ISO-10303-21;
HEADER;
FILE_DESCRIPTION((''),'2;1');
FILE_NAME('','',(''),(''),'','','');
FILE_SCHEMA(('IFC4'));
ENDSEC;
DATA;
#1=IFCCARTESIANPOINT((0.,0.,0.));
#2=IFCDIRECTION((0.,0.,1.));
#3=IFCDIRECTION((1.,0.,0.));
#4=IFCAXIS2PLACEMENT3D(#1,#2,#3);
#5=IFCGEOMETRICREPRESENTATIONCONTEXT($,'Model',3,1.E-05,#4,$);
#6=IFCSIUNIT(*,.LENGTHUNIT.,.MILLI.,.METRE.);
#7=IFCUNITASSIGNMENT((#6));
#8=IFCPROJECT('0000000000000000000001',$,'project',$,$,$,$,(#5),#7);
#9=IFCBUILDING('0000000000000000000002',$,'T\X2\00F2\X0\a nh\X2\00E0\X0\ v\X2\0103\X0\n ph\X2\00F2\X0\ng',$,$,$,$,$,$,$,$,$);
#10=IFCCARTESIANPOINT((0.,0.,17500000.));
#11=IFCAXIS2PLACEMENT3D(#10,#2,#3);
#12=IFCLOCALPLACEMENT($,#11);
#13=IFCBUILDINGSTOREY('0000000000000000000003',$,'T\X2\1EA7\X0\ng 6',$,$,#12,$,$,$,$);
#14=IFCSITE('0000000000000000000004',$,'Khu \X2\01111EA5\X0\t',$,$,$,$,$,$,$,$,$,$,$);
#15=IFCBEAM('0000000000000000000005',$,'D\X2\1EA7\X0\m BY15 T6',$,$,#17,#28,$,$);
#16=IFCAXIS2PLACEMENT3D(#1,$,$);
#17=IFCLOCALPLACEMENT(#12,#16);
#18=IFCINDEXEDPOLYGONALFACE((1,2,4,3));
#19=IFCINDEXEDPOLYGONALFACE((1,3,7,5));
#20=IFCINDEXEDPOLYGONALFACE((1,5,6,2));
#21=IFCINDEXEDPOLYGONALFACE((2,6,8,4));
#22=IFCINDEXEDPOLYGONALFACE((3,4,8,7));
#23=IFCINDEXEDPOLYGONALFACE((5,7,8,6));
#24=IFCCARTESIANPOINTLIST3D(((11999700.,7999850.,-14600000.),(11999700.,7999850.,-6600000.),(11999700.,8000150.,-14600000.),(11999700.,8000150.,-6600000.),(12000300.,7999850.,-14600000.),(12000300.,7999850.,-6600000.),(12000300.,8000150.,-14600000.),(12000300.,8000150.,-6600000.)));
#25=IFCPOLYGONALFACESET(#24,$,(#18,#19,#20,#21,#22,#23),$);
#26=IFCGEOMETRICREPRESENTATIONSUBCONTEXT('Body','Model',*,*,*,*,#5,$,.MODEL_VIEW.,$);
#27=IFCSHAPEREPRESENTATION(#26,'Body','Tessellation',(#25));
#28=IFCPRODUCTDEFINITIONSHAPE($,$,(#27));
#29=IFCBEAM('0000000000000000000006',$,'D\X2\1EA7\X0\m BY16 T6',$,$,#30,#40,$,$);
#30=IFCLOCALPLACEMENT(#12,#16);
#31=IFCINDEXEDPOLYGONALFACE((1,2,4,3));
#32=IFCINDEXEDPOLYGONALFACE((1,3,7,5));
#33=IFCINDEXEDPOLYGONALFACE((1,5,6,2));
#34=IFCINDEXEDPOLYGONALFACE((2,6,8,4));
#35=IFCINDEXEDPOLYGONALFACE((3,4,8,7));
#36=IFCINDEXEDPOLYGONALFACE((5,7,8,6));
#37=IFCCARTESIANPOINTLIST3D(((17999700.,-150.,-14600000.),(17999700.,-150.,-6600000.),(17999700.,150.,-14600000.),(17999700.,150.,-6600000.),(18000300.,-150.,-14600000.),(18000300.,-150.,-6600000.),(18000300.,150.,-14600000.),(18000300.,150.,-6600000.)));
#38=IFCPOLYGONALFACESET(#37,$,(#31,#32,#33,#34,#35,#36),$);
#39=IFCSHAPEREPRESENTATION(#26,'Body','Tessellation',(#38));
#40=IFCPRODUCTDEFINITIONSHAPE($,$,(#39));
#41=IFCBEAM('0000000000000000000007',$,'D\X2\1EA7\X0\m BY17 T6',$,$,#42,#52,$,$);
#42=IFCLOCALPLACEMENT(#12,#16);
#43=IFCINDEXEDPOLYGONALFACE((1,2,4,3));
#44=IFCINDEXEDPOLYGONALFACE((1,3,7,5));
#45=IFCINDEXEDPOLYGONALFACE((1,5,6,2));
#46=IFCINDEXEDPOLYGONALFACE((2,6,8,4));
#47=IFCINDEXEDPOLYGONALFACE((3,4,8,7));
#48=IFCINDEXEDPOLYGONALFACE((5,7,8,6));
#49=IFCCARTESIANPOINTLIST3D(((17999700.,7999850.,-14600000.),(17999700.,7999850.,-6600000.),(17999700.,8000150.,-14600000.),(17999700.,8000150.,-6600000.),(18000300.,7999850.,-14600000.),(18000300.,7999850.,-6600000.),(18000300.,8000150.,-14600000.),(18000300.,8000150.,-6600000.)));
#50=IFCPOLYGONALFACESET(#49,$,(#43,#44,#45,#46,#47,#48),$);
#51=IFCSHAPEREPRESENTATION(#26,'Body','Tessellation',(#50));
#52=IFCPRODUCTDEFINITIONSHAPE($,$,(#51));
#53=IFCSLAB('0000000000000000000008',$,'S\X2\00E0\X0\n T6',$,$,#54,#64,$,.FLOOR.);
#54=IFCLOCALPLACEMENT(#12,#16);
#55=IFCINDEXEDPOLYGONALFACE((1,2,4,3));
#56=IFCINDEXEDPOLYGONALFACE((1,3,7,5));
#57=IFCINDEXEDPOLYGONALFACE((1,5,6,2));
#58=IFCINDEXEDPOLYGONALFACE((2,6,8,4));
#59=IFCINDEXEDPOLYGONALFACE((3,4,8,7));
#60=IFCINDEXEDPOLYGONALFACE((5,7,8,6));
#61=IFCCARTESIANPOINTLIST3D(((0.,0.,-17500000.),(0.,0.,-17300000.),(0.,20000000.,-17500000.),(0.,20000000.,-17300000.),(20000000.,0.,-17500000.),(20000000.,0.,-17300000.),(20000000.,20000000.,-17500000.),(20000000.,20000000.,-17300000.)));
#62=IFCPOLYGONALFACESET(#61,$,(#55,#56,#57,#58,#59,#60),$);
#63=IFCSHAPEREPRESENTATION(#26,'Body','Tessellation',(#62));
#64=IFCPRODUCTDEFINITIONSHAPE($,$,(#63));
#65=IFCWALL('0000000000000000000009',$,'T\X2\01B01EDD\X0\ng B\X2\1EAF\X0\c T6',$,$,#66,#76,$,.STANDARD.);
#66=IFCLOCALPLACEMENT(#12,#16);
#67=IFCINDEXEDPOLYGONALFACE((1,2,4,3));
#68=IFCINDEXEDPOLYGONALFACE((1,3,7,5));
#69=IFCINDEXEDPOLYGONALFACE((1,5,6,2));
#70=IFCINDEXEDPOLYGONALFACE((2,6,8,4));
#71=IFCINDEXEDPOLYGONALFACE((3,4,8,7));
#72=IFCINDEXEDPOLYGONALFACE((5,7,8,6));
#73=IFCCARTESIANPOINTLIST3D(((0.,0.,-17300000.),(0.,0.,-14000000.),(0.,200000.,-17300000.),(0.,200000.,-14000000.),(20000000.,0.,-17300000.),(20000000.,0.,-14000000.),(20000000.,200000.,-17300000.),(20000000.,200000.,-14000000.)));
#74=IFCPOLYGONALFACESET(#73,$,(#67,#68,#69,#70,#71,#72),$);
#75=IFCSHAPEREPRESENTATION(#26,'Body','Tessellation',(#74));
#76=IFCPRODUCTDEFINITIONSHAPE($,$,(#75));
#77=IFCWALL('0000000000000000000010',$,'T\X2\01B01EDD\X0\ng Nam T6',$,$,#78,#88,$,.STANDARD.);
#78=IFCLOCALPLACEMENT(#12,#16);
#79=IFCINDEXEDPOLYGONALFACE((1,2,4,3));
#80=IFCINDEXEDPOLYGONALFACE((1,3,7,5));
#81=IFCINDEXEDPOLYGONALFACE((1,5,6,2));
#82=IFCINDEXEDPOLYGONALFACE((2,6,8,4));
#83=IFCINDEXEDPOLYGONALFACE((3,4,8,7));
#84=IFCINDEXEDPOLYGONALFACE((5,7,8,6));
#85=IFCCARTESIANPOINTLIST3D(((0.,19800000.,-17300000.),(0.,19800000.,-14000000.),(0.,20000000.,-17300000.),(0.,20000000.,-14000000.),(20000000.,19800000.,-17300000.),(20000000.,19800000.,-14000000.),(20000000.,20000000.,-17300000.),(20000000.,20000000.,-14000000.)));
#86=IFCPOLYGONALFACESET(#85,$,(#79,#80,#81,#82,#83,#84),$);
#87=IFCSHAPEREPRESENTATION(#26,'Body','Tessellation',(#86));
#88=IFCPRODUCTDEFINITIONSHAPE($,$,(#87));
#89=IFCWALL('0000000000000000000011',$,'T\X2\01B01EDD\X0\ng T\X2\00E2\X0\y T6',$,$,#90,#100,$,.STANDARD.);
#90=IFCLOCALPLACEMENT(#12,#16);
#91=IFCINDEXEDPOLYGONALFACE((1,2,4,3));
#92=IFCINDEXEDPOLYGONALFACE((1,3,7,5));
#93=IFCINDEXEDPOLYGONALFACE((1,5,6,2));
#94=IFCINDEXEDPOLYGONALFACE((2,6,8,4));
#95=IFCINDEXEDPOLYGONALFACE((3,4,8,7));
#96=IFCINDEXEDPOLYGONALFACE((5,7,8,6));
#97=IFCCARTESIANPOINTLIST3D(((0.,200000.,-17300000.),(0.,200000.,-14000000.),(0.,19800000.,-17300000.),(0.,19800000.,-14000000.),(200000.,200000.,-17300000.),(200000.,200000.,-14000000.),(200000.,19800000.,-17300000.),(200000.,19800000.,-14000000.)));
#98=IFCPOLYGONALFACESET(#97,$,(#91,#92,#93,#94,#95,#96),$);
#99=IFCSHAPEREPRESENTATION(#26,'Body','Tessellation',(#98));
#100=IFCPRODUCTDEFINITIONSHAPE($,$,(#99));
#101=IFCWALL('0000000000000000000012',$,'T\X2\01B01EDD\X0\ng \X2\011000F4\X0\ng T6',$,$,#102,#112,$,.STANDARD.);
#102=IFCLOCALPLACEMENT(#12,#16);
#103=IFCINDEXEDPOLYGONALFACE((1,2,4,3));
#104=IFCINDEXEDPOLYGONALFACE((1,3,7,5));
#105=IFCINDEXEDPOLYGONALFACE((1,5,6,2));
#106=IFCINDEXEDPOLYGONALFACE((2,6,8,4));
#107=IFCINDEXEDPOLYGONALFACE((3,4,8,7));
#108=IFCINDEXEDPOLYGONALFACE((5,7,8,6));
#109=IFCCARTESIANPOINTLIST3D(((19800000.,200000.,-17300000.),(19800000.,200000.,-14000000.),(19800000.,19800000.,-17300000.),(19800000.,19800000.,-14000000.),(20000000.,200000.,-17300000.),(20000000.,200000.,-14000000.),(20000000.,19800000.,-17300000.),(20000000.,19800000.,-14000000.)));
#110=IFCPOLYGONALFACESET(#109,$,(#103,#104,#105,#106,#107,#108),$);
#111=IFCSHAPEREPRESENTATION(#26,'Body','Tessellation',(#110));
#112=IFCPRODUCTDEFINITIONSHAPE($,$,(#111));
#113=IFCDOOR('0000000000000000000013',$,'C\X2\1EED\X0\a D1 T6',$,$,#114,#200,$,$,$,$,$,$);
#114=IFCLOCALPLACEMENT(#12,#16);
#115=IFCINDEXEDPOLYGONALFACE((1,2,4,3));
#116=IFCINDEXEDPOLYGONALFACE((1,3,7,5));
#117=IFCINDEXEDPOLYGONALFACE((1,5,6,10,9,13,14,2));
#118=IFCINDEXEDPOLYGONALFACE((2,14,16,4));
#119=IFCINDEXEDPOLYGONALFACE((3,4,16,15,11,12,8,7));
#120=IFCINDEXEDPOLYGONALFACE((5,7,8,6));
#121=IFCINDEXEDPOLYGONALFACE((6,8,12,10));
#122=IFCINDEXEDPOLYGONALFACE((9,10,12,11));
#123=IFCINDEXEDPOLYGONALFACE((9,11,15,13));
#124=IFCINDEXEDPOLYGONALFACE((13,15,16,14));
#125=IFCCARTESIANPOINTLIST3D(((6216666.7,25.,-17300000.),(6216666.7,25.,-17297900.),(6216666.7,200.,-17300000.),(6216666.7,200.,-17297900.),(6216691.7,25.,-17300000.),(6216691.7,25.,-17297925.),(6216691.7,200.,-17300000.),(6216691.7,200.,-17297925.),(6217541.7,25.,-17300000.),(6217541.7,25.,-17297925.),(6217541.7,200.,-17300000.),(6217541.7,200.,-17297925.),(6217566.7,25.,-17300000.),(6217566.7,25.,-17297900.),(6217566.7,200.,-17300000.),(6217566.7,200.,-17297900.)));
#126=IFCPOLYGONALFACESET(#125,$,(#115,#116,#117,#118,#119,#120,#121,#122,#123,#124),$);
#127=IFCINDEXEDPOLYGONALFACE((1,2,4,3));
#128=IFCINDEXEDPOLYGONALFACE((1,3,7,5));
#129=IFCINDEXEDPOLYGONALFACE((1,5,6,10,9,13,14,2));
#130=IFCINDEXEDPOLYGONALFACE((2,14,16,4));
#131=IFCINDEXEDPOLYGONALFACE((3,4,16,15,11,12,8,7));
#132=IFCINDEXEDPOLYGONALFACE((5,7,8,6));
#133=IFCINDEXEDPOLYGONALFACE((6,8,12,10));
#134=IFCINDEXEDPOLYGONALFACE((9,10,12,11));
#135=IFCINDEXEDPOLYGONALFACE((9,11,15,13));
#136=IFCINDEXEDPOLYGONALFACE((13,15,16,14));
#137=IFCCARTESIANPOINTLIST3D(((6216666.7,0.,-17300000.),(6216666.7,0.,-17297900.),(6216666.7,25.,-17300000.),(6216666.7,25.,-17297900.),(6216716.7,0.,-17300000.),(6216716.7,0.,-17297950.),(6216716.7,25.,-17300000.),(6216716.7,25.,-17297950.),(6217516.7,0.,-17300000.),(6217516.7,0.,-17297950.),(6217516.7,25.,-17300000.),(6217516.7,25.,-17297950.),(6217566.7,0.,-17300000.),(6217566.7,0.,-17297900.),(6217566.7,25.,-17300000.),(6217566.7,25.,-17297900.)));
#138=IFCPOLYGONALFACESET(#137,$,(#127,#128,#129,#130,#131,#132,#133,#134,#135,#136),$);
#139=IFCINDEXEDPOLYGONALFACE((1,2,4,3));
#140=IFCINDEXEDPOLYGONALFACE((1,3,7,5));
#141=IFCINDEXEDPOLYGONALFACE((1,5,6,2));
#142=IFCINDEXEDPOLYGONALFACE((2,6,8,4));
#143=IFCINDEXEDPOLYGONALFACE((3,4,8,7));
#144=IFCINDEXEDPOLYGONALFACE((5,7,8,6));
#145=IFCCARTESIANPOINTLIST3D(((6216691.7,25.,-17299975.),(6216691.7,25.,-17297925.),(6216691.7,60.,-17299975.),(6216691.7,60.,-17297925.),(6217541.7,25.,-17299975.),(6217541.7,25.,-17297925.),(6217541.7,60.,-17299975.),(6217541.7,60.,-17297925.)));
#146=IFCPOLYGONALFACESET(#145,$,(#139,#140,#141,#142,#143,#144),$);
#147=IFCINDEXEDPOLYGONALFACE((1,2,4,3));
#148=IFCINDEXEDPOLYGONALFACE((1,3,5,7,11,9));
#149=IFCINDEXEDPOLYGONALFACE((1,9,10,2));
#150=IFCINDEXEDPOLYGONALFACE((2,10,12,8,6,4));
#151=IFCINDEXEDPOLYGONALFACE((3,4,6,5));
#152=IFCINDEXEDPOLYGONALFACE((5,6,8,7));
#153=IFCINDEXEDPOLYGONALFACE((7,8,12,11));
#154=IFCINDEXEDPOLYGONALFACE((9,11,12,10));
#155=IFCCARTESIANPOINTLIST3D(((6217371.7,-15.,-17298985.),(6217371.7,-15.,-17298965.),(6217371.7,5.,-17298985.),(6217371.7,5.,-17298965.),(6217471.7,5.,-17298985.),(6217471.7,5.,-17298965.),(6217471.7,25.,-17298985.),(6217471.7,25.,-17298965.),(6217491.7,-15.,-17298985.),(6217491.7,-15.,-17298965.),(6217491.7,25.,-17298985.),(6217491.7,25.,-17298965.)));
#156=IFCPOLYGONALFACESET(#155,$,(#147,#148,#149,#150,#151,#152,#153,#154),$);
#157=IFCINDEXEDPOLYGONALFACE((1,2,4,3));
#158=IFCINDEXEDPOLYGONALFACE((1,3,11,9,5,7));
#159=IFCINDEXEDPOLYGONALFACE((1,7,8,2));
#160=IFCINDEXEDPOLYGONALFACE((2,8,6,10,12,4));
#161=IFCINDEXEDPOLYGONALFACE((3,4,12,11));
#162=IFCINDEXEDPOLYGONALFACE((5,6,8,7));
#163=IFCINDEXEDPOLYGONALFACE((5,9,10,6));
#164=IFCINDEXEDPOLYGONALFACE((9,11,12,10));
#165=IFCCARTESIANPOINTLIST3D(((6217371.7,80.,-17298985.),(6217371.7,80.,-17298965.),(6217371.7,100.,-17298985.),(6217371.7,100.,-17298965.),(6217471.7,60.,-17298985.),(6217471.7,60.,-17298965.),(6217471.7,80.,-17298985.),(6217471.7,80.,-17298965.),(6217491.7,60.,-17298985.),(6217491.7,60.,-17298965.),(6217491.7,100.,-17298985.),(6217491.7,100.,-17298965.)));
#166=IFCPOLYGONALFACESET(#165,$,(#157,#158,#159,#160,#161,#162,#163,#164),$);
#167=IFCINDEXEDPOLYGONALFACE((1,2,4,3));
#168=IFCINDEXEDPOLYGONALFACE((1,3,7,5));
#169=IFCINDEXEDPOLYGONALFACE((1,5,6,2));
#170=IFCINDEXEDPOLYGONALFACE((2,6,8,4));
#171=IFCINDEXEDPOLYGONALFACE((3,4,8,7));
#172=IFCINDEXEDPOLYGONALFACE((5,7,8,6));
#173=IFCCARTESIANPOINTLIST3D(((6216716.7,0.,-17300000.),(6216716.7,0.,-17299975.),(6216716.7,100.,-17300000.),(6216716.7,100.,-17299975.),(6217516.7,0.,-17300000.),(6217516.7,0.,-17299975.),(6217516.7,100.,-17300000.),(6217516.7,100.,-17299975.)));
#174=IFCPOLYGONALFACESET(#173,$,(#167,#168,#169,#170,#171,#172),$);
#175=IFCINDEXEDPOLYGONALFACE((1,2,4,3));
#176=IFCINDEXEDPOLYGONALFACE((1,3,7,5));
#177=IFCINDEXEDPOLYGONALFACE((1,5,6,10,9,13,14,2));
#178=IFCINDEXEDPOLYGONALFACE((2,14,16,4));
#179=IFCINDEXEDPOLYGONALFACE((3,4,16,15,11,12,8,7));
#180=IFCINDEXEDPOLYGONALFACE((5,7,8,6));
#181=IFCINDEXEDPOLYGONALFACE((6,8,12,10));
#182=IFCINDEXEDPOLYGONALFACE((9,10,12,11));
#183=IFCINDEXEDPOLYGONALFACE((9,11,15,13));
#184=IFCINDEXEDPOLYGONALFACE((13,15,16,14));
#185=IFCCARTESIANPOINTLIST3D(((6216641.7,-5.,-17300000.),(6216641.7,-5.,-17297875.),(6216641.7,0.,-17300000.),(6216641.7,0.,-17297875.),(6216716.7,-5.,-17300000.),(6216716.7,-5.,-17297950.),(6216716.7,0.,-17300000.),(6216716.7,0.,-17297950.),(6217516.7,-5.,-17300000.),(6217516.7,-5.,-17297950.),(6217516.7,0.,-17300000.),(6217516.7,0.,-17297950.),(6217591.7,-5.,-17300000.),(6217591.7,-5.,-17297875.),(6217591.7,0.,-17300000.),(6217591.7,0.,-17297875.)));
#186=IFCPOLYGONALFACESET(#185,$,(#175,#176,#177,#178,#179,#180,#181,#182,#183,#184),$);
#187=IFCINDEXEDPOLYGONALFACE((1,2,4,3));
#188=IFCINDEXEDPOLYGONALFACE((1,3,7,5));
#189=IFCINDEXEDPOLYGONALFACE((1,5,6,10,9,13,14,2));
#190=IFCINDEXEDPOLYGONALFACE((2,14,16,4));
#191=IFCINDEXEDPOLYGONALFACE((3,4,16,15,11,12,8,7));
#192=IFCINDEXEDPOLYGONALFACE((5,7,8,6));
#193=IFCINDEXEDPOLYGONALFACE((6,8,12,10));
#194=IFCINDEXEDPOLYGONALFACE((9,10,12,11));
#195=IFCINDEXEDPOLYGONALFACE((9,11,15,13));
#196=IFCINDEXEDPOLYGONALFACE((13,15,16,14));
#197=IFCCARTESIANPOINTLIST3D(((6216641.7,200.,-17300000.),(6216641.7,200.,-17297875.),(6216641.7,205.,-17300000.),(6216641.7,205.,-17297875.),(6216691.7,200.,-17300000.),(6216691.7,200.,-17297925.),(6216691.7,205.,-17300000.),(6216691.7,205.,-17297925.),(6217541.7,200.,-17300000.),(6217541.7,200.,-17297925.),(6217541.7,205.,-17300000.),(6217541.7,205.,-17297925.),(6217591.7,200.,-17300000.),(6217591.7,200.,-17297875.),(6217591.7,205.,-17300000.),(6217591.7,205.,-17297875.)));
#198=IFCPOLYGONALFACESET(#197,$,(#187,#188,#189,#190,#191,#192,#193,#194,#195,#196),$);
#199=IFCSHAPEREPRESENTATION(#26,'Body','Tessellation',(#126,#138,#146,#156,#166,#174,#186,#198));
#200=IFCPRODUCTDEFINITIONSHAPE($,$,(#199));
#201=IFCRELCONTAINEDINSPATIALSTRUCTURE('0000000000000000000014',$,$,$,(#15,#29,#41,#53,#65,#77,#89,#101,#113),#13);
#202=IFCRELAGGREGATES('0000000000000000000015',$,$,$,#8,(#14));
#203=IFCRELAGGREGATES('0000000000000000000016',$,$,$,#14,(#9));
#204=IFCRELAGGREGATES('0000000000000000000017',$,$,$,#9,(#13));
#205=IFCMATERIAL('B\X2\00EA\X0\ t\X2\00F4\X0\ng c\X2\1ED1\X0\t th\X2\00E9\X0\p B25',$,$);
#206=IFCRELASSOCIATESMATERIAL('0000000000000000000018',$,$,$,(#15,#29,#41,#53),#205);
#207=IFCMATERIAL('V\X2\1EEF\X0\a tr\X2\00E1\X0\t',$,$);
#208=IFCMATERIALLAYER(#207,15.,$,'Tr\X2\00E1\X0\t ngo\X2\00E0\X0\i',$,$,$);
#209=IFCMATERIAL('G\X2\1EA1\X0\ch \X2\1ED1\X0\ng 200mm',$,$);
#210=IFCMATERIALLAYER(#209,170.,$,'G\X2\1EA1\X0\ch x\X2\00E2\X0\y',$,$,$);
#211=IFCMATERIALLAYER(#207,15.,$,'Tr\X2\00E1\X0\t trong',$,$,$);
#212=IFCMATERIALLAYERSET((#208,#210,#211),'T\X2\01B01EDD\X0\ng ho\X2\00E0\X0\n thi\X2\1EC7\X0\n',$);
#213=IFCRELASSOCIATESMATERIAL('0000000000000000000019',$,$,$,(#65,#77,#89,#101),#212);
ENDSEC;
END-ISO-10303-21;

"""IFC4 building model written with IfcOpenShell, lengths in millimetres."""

from ifc_helpers import new_model, entity, si_unit, frame, origin_with_axes, place, context, subcontext, project, spatial, line, indexed_curve, outline, extrude, material, layer, layer_set, layer_usage, element, save


model = new_model("IFC4")

# Units and contexts
model_context = context("Model", 3, precision=1e-05, world=origin_with_axes())
body_context = subcontext(model_context, "Body", "Model", "MODEL_VIEW")
ifc_project = project(units=[si_unit("LENGTHUNIT", "METRE", prefix="MILLI")], contexts=[model_context])

# Site, building, storey
site = spatial("IfcSite", under=ifc_project, Name="Khu đất")
building = spatial("IfcBuilding", under=site, Name="Tòa nhà văn phòng")
storey_placement = place(None, frame((0.0, 0.0, 17500000.0), z_axis=(0.0, 0.0, 1.0), x_axis=(1.0, 0.0, 0.0)))
storey = spatial("IfcBuildingStorey", under=building, at=storey_placement, Name="Tầng 6")

# Shared definitions
ifc_material_1 = material(Name="Bê tông cốt thép B25")

# Beams
for number, where, z_axis, x_axis, name in (
    (1, (12000000.0, 8000000.0, -14600000.0), (0.0, 0.0, 1.0), (0.0, 1.0, 0.0), "Dầm BY15 T6"),
    (2, (18000000.0, 0.0, -14600000.0), (0.0, 0.0, 1.0), (0.0, 1.0, 0.0), "Dầm BY16 T6"),
    (3, (18000000.0, 8000000.0, -14600000.0), (0.0, 0.0, 1.0), (0.0, 1.0, 0.0), "Dầm BY17 T6"),
):
    element("IfcBeam", number, at=place(storey_placement, frame(where, z_axis=z_axis, x_axis=x_axis)), inside=storey, material=ifc_material_1, Name=name, context=body_context, shape_type="SweptSolid", body=[
        extrude(entity("IfcRectangleProfileDef", None, None, None, 300.0, 600.0), origin_with_axes(), (0.0, 0.0, 1.0), 8000000.0),
    ])

# Slab
slab_placement = place(storey_placement, frame((0.0, 0.0, -17500000.0), z_axis=(0.0, 0.0, 1.0), x_axis=(1.0, 0.0, 0.0)))
element("IfcSlab", 4, at=slab_placement, inside=storey, material=ifc_material_1, Name="Sàn T6", PredefinedType="FLOOR", context=body_context, shape_type="SweptSolid", body=[
    extrude(outline(indexed_curve([(0.0, 0.0), (20000000.0, 0.0), (20000000.0, 20000000.0), (0.0, 20000000.0), (0.0, 0.0)])), None, (0.0, 0.0, 1.0), 200000.0),
])

# Walls
ifc_material_2 = material(Name="Vữa trát")
ifc_layer_1 = layer(ifc_material_2, 15.0, Name="Trát ngoài")
ifc_material_3 = material(Name="Gạch ống 200mm")
ifc_layer_2 = layer(ifc_material_3, 170.0, Name="Gạch xây")
ifc_layer_3 = layer(ifc_material_2, 15.0, Name="Trát trong")
ifc_layer_set = layer_set([ifc_layer_1, ifc_layer_2, ifc_layer_3], Name="Tường hoàn thiện")
ifc_layer_usage_1 = layer_usage(ifc_layer_set, "AXIS2", "POSITIVE", 0.0)
wall_1_placement = place(storey_placement, frame((0.0, 0.0, -17300000.0), z_axis=(0.0, 0.0, 1.0), x_axis=(1.0, 0.0, 0.0)))
element("IfcWall", 5, at=wall_1_placement, inside=storey, material=ifc_layer_usage_1, Name="Tường Bắc T6", PredefinedType="STANDARD", context=body_context, shape_type="SweptSolid", body=[
    extrude(outline(indexed_curve([(0.0, 0.0), (0.0, 200000.0), (20000000.0, 200000.0), (20000000.0, 0.0), (0.0, 0.0)], self_intersect=False)), origin_with_axes(), (0.0, 0.0, 1.0), 3300000.0),
])
ifc_layer_usage_2 = layer_usage(ifc_layer_set, "AXIS2", "POSITIVE", 0.0)
wall_2_placement = place(storey_placement, frame((0.0, 19800000.0, -17300000.0), z_axis=(0.0, 0.0, 1.0), x_axis=(1.0, 0.0, 0.0)))
element("IfcWall", 6, at=wall_2_placement, inside=storey, material=ifc_layer_usage_2, Name="Tường Nam T6", PredefinedType="STANDARD", context=body_context, shape_type="SweptSolid", body=[
    extrude(outline(indexed_curve([(0.0, 0.0), (0.0, 200000.0), (20000000.0, 200000.0), (20000000.0, 0.0), (0.0, 0.0)], self_intersect=False)), origin_with_axes(), (0.0, 0.0, 1.0), 3300000.0),
])
ifc_layer_usage_3 = layer_usage(ifc_layer_set, "AXIS2", "POSITIVE", 0.0)
wall_3_placement = place(storey_placement, frame((0.0, 200000.0, -17300000.0), z_axis=(0.0, 0.0, 1.0), x_axis=(1.0, 0.0, 0.0)))
element("IfcWall", 7, at=wall_3_placement, inside=storey, material=ifc_layer_usage_3, Name="Tường Tây T6", PredefinedType="STANDARD", context=body_context, shape_type="SweptSolid", body=[
    extrude(outline(indexed_curve([(0.0, 0.0), (0.0, 19600000.0), (200000.0, 19600000.0), (200000.0, 0.0), (0.0, 0.0)], self_intersect=False)), origin_with_axes(), (0.0, 0.0, 1.0), 3300000.0),
])
ifc_layer_usage_4 = layer_usage(ifc_layer_set, "AXIS2", "POSITIVE", 0.0)
wall_4_placement = place(storey_placement, frame((19800000.0, 200000.0, -17300000.0), z_axis=(0.0, 0.0, 1.0), x_axis=(1.0, 0.0, 0.0)))
element("IfcWall", 8, at=wall_4_placement, inside=storey, material=ifc_layer_usage_4, Name="Tường Đông T6", PredefinedType="STANDARD", context=body_context, shape_type="SweptSolid", body=[
    extrude(outline(indexed_curve([(0.0, 0.0), (0.0, 19600000.0), (200000.0, 19600000.0), (200000.0, 0.0), (0.0, 0.0)], self_intersect=False)), origin_with_axes(), (0.0, 0.0, 1.0), 3300000.0),
])

# Door
door_1_placement = place(storey_placement, frame((6216666.7, 0.0, -17300000.0), z_axis=(0.0, 0.0, 1.0), x_axis=(1.0, 0.0, 0.0)))
element("IfcDoor", 9, at=door_1_placement, inside=storey, Name="Cửa D1 T6", context=body_context, shape_type="SolidModel", body=[
    extrude(outline(indexed_curve([(0.0, 0.0), (0.0, 2100.0), (900.0, 2100.0), (900.0, 0.0), (875.0, 0.0), (875.0, 2075.0), (25.0, 2075.0), (25.0, 0.0)], segments=[line(1, 2, 3, 4, 5, 6, 7, 8, 1)])), frame((0.0, 25.0, 0.0), z_axis=(0.0, -1.0, 0.0), x_axis=(1.0, 0.0, 0.0)), (0.0, 0.0, -1.0), 175.0),
    extrude(outline(indexed_curve([(0.0, 0.0), (0.0, 2100.0), (900.0, 2100.0), (900.0, 0.0), (850.0, 0.0), (850.0, 2050.0), (50.0, 2050.0), (50.0, 0.0)], segments=[line(1, 2, 3, 4, 5, 6, 7, 8, 1)])), frame((0.0, 0.0, 0.0), z_axis=(0.0, -1.0, 0.0), x_axis=(1.0, 0.0, 0.0)), (0.0, 0.0, -1.0), 25.0),
    extrude(outline(indexed_curve([(0.0, 0.0), (850.0, 0.0), (850.0, 35.0), (0.0, 35.0)], segments=[line(1, 2, 3, 4, 1)])), frame((25.0, 25.0, 25.0), z_axis=(0.0, 0.0, 1.0), x_axis=(1.0, 0.0, 0.0)), (0.0, 0.0, 1.0), 2050.0),
    extrude(outline(indexed_curve([(0.0, 0.0), (0.0, -40.0), (-120.0, -40.0), (-120.0, -20.0), (-20.0, -20.0), (-20.0, 0.0)], segments=[line(1, 2, 3, 4, 5, 6, 1)])), frame((825.0, 25.0, 1015.0), z_axis=(0.0, 0.0, 1.0), x_axis=(1.0, 0.0, 0.0)), (0.0, 0.0, 1.0), 20.0),
    extrude(outline(indexed_curve([(0.0, 0.0), (0.0, 40.0), (-120.0, 40.0), (-120.0, 20.0), (-20.0, 20.0), (-20.0, 0.0)], segments=[line(1, 2, 3, 4, 5, 6, 1)])), frame((825.0, 60.0, 1015.0), z_axis=(0.0, 0.0, 1.0), x_axis=(1.0, 0.0, 0.0)), (0.0, 0.0, 1.0), 20.0),
    extrude(outline(indexed_curve([(0.0, 0.0), (800.0, 0.0), (800.0, 100.0), (0.0, 100.0)], segments=[line(1, 2, 3, 4, 1)])), frame((50.0, 0.0, 0.0), z_axis=(0.0, 0.0, 1.0), x_axis=(1.0, 0.0, 0.0)), (0.0, 0.0, 1.0), 25.0),
    extrude(outline(indexed_curve([(0.0, 0.0), (0.0, 2125.0), (950.0, 2125.0), (950.0, 0.0), (875.0, 0.0), (875.0, 2050.0), (75.0, 2050.0), (75.0, 0.0)], segments=[line(1, 2, 3, 4, 5, 6, 7, 8, 1)])), frame((-25.0, -5.0, 0.0), z_axis=(0.0, -1.0, 0.0), x_axis=(1.0, 0.0, 0.0)), (0.0, 0.0, -1.0), 5.0),
    extrude(outline(indexed_curve([(0.0, 0.0), (0.0, 2125.0), (950.0, 2125.0), (950.0, 0.0), (900.0, 0.0), (900.0, 2075.0), (50.0, 2075.0), (50.0, 0.0)], segments=[line(1, 2, 3, 4, 5, 6, 7, 8, 1)])), frame((-25.0, 200.0, 0.0), z_axis=(0.0, -1.0, 0.0), x_axis=(1.0, 0.0, 0.0)), (0.0, 0.0, -1.0), 5.0),
])

save(model, "model.ifc")
